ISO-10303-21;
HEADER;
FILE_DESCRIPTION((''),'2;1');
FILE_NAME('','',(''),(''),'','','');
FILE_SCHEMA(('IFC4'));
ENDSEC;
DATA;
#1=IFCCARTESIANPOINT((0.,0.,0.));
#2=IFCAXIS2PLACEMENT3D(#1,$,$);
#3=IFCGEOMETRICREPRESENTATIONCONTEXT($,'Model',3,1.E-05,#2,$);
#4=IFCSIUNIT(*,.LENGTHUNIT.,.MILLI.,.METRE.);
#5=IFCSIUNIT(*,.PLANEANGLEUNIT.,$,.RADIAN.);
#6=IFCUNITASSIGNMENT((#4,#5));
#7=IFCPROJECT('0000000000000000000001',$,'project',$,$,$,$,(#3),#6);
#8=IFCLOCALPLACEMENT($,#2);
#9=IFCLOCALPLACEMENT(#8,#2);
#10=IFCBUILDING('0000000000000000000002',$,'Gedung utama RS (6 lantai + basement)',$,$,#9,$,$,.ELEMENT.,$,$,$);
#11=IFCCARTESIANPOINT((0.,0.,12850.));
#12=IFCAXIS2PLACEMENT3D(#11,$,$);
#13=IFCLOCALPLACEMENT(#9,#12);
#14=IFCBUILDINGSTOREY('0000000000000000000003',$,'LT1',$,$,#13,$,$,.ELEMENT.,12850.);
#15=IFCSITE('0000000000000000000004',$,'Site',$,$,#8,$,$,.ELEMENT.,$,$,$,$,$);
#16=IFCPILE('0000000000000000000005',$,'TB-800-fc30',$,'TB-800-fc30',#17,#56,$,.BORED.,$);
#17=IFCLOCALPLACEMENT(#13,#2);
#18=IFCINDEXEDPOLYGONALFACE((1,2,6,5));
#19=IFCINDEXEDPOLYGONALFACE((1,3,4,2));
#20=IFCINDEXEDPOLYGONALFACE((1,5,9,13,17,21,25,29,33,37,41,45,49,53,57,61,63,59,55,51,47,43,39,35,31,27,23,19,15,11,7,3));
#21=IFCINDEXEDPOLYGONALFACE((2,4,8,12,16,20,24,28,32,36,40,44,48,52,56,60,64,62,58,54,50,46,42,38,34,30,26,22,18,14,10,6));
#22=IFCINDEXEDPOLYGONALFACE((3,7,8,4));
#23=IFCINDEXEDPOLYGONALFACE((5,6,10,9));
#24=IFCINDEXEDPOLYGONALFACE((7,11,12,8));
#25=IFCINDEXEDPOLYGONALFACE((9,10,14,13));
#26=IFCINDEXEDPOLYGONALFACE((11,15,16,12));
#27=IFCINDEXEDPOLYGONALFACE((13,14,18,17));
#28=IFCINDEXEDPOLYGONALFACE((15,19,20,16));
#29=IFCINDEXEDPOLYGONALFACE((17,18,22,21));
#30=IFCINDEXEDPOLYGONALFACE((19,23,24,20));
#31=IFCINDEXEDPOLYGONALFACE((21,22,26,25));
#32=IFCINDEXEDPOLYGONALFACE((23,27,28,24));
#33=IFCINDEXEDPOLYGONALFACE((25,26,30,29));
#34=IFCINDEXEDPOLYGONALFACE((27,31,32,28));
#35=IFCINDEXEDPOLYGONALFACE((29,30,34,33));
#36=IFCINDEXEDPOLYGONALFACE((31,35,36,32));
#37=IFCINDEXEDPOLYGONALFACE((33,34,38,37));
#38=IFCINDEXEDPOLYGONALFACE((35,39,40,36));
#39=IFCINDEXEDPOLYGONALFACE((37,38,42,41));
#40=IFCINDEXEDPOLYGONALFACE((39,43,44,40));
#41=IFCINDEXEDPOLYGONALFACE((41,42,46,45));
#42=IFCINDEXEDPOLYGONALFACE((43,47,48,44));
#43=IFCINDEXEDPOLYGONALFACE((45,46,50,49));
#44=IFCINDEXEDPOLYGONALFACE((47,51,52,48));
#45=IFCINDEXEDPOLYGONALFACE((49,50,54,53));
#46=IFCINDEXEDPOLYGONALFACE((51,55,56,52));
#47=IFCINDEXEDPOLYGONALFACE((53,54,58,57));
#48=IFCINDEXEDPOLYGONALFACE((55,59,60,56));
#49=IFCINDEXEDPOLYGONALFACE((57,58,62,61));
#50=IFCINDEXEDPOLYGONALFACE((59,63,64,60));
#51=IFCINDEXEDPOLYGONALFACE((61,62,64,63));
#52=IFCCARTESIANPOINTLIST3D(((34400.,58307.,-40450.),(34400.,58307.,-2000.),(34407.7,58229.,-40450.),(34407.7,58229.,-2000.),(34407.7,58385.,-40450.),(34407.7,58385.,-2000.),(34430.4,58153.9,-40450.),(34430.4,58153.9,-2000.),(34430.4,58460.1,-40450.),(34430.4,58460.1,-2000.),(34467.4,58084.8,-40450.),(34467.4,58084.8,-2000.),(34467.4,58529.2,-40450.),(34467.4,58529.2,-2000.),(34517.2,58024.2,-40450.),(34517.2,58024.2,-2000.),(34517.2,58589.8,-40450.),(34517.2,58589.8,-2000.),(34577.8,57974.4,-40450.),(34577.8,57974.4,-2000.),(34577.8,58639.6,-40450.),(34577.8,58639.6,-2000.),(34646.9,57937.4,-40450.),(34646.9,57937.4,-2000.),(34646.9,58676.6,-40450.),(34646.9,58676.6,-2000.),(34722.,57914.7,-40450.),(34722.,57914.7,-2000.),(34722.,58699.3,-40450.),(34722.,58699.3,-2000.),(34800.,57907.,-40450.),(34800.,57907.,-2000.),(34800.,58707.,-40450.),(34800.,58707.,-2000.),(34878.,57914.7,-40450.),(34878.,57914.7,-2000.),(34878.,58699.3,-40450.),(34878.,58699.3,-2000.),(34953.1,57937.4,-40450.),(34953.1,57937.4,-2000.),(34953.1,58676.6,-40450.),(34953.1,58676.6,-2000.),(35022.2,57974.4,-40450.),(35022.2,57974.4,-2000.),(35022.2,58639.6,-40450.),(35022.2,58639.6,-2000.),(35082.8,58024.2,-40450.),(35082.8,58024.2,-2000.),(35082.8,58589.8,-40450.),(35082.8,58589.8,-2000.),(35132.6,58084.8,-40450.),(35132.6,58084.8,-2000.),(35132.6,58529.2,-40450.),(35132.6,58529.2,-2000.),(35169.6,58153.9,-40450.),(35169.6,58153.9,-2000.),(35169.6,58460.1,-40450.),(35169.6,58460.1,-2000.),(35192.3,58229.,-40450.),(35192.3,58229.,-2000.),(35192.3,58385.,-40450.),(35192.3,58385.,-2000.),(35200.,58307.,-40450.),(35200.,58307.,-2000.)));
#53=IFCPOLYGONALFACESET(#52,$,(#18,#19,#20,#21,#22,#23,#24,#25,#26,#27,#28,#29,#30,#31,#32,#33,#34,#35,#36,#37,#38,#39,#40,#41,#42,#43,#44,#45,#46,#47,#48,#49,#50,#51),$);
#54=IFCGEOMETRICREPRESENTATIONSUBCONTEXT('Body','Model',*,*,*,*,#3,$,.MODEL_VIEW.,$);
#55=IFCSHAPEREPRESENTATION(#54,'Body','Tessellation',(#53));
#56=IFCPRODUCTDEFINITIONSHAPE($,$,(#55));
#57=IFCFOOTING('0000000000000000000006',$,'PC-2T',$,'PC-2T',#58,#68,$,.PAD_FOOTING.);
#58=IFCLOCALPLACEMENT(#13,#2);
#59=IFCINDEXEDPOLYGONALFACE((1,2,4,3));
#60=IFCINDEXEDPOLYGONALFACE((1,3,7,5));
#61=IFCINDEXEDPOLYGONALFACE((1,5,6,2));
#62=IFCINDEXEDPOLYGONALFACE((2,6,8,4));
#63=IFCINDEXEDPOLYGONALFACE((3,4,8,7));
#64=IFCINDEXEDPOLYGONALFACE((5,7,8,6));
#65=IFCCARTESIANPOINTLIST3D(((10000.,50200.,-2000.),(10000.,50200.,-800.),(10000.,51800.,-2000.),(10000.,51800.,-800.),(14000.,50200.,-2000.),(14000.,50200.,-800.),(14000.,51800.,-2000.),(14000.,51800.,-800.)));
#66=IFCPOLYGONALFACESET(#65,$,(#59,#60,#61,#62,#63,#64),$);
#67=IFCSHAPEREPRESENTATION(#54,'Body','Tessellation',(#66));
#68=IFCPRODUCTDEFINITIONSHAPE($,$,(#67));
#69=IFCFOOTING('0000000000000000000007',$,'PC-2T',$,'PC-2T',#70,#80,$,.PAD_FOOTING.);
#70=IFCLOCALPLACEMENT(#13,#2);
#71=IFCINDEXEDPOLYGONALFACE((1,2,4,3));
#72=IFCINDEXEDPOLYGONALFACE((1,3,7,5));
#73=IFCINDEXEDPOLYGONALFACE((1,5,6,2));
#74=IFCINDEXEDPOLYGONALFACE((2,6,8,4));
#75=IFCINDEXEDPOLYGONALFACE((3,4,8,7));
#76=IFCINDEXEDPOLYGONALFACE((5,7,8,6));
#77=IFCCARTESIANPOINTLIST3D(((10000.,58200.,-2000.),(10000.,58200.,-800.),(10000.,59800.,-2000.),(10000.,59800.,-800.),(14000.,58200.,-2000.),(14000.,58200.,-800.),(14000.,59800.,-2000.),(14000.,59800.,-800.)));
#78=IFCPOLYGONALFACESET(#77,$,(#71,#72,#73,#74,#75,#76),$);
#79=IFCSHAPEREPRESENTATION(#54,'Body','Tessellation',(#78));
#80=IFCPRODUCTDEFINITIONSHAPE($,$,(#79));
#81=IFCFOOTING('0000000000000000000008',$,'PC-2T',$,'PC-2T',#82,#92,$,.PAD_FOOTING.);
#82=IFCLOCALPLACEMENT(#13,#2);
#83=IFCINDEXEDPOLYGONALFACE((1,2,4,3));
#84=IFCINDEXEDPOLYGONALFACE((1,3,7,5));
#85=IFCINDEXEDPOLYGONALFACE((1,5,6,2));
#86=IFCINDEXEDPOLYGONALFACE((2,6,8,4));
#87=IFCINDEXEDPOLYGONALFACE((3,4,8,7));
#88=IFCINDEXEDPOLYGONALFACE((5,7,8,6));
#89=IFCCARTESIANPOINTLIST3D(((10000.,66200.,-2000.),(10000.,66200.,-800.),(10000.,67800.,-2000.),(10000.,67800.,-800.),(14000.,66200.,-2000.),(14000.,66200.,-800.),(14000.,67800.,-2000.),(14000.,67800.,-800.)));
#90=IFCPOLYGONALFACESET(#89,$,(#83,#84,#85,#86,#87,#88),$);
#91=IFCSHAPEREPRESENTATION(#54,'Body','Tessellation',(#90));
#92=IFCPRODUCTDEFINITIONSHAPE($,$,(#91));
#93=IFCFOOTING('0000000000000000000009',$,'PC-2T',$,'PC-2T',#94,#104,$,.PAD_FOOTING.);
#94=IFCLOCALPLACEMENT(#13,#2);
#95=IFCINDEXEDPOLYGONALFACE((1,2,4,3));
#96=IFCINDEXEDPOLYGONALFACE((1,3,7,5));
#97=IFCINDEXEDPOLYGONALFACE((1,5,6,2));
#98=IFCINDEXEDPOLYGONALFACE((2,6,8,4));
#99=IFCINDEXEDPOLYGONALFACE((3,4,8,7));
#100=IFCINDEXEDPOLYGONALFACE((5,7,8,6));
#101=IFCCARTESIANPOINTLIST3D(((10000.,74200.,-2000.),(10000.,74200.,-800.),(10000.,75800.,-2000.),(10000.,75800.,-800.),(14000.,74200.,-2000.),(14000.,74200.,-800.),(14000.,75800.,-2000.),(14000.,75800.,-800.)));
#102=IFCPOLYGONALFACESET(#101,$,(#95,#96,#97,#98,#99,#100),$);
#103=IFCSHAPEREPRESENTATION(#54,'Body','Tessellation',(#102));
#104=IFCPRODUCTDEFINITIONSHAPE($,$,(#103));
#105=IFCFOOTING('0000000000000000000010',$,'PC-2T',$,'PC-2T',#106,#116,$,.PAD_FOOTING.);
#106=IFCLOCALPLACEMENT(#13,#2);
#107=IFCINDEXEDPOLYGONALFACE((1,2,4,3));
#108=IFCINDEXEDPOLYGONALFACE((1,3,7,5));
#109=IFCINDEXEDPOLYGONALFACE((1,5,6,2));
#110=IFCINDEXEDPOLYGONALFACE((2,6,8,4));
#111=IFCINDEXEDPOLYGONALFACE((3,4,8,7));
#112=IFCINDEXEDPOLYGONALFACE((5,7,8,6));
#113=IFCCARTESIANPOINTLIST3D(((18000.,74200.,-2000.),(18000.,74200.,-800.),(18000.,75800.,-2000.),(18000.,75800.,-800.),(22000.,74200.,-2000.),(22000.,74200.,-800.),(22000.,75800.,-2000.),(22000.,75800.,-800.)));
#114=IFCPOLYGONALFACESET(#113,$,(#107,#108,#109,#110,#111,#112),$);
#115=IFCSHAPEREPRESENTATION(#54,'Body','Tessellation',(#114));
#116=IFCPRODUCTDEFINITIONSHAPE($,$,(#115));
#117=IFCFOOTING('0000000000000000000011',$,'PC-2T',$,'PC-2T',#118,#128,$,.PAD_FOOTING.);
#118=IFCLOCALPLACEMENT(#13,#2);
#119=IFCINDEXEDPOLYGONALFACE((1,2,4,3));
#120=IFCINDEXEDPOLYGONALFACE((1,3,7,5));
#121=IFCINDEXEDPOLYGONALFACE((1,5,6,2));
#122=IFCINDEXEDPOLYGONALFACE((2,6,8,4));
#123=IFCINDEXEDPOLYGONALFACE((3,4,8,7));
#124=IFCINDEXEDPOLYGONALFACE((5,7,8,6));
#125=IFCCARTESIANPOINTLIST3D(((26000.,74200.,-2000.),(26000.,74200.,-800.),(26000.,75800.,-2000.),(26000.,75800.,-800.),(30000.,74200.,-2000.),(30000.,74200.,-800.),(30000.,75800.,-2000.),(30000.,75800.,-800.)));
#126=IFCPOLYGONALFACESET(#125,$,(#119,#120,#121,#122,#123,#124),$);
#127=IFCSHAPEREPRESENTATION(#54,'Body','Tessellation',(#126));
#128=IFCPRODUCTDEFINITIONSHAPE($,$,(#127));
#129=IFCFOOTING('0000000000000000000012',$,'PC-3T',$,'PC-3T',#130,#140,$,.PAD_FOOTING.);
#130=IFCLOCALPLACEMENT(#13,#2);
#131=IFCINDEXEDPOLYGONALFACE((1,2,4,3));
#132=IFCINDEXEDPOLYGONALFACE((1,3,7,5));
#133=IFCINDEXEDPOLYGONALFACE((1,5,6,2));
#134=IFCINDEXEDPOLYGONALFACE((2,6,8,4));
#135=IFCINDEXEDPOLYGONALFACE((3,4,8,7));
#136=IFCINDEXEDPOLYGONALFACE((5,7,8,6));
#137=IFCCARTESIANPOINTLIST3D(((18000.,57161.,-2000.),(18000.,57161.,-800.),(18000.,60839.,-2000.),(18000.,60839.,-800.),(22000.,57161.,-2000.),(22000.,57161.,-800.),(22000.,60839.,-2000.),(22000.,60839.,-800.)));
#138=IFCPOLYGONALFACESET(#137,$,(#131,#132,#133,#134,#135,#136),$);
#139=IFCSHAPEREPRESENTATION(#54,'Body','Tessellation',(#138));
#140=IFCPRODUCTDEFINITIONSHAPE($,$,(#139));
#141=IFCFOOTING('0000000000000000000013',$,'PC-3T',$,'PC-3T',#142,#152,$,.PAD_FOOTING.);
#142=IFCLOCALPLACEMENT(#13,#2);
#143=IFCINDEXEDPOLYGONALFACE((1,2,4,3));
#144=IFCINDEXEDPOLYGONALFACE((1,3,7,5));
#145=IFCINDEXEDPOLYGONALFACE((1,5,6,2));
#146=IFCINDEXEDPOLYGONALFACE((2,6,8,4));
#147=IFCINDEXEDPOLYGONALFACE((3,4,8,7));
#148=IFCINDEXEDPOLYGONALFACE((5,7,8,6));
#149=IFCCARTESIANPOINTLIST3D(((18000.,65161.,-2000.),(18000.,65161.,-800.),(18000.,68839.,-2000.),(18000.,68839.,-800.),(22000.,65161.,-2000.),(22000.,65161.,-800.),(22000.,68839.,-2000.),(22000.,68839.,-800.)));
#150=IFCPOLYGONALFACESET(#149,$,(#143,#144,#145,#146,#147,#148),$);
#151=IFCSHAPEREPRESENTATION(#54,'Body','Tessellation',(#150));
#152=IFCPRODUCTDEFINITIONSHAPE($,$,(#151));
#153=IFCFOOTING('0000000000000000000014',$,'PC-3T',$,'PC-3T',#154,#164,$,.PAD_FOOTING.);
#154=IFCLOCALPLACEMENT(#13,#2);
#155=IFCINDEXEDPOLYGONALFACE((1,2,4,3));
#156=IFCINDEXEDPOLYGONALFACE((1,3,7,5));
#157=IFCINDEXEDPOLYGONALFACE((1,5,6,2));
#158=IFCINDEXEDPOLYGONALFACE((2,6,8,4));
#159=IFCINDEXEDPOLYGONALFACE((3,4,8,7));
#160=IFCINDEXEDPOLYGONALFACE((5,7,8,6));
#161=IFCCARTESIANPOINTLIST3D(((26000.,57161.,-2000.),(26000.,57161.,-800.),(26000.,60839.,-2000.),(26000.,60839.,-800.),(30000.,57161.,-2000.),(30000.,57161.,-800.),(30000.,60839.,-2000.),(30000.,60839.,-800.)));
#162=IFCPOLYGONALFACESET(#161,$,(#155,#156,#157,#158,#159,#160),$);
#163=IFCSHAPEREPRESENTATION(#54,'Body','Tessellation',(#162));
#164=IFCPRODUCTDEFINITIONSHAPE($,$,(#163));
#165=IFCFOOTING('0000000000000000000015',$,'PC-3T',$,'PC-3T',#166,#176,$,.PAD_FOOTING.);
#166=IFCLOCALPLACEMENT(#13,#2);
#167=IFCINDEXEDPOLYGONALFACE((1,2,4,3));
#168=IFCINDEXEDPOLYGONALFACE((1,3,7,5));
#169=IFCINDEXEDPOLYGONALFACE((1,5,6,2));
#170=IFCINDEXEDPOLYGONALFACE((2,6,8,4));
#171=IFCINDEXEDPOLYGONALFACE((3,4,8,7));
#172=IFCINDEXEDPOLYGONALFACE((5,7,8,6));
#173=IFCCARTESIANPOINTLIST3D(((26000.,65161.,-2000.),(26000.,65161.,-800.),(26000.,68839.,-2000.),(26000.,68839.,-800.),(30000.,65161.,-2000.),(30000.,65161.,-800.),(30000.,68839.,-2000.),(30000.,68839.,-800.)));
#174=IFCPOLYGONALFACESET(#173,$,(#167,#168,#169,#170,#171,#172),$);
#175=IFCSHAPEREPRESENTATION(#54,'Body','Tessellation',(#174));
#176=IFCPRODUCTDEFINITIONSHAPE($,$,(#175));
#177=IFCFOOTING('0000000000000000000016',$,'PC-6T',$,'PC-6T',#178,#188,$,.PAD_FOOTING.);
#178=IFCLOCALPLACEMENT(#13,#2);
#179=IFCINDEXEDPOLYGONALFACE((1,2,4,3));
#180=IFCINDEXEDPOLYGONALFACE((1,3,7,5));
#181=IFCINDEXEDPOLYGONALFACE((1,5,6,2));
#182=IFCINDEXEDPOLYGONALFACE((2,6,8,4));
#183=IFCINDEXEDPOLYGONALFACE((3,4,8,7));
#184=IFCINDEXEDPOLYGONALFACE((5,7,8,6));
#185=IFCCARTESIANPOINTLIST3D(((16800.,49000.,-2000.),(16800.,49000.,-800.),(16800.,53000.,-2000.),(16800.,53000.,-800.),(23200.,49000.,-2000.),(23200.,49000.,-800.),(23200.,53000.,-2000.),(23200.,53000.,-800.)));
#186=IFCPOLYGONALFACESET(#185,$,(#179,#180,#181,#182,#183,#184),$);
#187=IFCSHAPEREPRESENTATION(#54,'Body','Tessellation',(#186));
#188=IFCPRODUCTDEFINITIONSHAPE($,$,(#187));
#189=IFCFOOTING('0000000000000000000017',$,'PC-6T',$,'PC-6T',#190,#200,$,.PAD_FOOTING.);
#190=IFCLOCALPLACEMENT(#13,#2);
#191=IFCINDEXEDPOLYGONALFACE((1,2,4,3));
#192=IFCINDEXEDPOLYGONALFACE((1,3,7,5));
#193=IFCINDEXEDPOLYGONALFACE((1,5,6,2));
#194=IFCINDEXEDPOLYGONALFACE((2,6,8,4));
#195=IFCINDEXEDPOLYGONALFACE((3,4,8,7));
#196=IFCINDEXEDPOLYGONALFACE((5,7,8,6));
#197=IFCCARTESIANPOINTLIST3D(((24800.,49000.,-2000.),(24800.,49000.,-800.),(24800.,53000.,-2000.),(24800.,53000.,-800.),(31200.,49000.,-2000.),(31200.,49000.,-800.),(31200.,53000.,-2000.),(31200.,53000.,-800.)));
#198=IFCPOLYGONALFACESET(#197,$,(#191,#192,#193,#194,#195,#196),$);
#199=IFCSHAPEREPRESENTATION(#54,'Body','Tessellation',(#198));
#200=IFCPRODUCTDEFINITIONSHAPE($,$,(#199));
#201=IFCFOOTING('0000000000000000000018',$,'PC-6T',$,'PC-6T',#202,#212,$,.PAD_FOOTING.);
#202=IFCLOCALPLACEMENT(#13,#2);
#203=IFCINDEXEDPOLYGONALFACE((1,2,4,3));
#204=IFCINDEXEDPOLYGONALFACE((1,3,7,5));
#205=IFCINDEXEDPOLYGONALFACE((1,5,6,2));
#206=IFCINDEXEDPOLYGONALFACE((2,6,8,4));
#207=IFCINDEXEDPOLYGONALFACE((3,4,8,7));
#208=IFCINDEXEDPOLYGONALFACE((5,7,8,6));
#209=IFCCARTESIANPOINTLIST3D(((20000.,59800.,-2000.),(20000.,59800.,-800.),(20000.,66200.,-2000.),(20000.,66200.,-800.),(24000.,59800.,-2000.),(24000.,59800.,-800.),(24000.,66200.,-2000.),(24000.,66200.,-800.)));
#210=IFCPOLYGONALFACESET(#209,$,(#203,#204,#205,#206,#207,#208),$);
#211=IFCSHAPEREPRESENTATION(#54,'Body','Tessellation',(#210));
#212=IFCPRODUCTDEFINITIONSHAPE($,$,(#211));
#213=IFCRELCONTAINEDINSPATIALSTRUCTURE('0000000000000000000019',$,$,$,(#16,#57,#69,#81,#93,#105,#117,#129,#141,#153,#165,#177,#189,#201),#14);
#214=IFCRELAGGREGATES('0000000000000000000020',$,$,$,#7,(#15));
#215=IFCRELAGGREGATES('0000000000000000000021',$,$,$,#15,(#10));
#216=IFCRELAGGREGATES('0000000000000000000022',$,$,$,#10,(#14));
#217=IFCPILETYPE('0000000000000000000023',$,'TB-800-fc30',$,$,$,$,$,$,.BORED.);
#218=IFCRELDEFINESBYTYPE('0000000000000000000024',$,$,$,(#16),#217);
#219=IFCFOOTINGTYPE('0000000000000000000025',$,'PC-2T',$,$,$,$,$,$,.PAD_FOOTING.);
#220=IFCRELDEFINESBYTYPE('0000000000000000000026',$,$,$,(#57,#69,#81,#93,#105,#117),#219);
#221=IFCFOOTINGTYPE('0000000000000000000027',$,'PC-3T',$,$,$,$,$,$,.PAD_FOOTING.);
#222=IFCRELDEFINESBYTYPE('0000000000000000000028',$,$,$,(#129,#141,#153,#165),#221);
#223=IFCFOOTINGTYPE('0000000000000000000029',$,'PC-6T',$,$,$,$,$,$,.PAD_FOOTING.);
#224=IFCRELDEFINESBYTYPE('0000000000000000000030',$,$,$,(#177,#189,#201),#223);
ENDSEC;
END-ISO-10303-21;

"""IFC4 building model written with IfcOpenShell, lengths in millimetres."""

from ifc_helpers import new_model, si_unit, frame, origin, origin_2d, place, context, subcontext, project, spatial, rectangle, circle, extrude, material_profile, profile_set, profile_usage, type_object, element, save


model = new_model("IFC4")

# Units and contexts
model_context = context("Model", 3, precision=1e-05, world=origin())
body_context = subcontext(model_context, "Body", "Model", "MODEL_VIEW")
ifc_project = project(units=[si_unit("LENGTHUNIT", "METRE", prefix="MILLI"), si_unit("PLANEANGLEUNIT", "RADIAN")], contexts=[model_context])

# Site, building, storey
site_placement = place(None, origin())
site = spatial("IfcSite", under=ifc_project, at=site_placement, Name="Site", CompositionType="ELEMENT")
building_placement = place(site_placement, origin())
building = spatial("IfcBuilding", under=site, at=building_placement, Name="Gedung utama RS (6 lantai + basement)", CompositionType="ELEMENT")
storey_placement = place(building_placement, frame((0.0, 0.0, 12850.0)))
storey = spatial("IfcBuildingStorey", under=building, at=storey_placement, Name="LT1", CompositionType="ELEMENT", Elevation=12850.0)

# Pile
ifc_material_profile_1 = material_profile(None, circle(Radius=400.0, at=origin_2d()), Name="TB-800-fc30")
ifc_profile_set_1 = profile_set([ifc_material_profile_1], Name="TB-800-fc30")
ifc_profile_usage_1 = profile_usage(ifc_profile_set_1, cardinal=5)
pile_type = type_object("IfcPileType", Name="TB-800-fc30", PredefinedType="BORED", material=ifc_profile_set_1)
for number, where, z_axis, x_axis, name in (
    (1, (34800.0, 58307.0, -40450.0), (0.0, 0.0, 1.0), (1.0, 0.0, 0.0), "TB-800-fc30"),
):
    element("IfcPile", number, at=place(storey_placement, frame(where, z_axis=z_axis, x_axis=x_axis)), inside=storey, type_object=pile_type, material=ifc_profile_usage_1, Name=name, ObjectType="TB-800-fc30", PredefinedType="BORED", context=body_context, shape_type="SweptSolid", body=[
        extrude(circle(Radius=400.0, at=origin_2d()), origin(), (0.0, 0.0, 1.0), 38450.0),
    ])

# Footings
ifc_material_profile_2 = material_profile(None, rectangle(XDim=4000.0, YDim=1600.0, at=origin_2d()), Name="PC-2T")
ifc_profile_set_2 = profile_set([ifc_material_profile_2], Name="PC-2T")
ifc_profile_usage_2 = profile_usage(ifc_profile_set_2, cardinal=5)
footing_type_1 = type_object("IfcFootingType", Name="PC-2T", PredefinedType="PAD_FOOTING", material=ifc_profile_set_2)
for number, where, z_axis, x_axis, name in (
    (2, (12000.0, 51000.0, -2000.0), (0.0, 0.0, 1.0), (1.0, 0.0, 0.0), "PC-2T"),
    (3, (12000.0, 59000.0, -2000.0), (0.0, 0.0, 1.0), (1.0, 0.0, 0.0), "PC-2T"),
    (4, (12000.0, 67000.0, -2000.0), (0.0, 0.0, 1.0), (1.0, 0.0, 0.0), "PC-2T"),
    (5, (12000.0, 75000.0, -2000.0), (0.0, 0.0, 1.0), (1.0, 0.0, 0.0), "PC-2T"),
    (6, (20000.0, 75000.0, -2000.0), (0.0, 0.0, 1.0), (1.0, 0.0, 0.0), "PC-2T"),
    (7, (28000.0, 75000.0, -2000.0), (0.0, 0.0, 1.0), (1.0, 0.0, 0.0), "PC-2T"),
):
    element("IfcFooting", number, at=place(storey_placement, frame(where, z_axis=z_axis, x_axis=x_axis)), inside=storey, type_object=footing_type_1, material=ifc_profile_usage_2, Name=name, ObjectType="PC-2T", PredefinedType="PAD_FOOTING", context=body_context, shape_type="SweptSolid", body=[
        extrude(rectangle(XDim=4000.0, YDim=1600.0, at=origin_2d()), origin(), (0.0, 0.0, 1.0), 1200.0),
    ])
ifc_material_profile_3 = material_profile(None, rectangle(XDim=4000.0, YDim=3678.0, at=origin_2d()), Name="PC-3T")
ifc_profile_set_3 = profile_set([ifc_material_profile_3], Name="PC-3T")
ifc_profile_usage_3 = profile_usage(ifc_profile_set_3, cardinal=5)
footing_type_2 = type_object("IfcFootingType", Name="PC-3T", PredefinedType="PAD_FOOTING", material=ifc_profile_set_3)
for number, where, z_axis, x_axis, name in (
    (8, (20000.0, 59000.0, -2000.0), (0.0, 0.0, 1.0), (1.0, 0.0, 0.0), "PC-3T"),
    (9, (20000.0, 67000.0, -2000.0), (0.0, 0.0, 1.0), (1.0, 0.0, 0.0), "PC-3T"),
    (10, (28000.0, 59000.0, -2000.0), (0.0, 0.0, 1.0), (1.0, 0.0, 0.0), "PC-3T"),
    (11, (28000.0, 67000.0, -2000.0), (0.0, 0.0, 1.0), (1.0, 0.0, 0.0), "PC-3T"),
):
    element("IfcFooting", number, at=place(storey_placement, frame(where, z_axis=z_axis, x_axis=x_axis)), inside=storey, type_object=footing_type_2, material=ifc_profile_usage_3, Name=name, ObjectType="PC-3T", PredefinedType="PAD_FOOTING", context=body_context, shape_type="SweptSolid", body=[
        extrude(rectangle(XDim=4000.0, YDim=3678.0, at=origin_2d()), origin(), (0.0, 0.0, 1.0), 1200.0),
    ])
ifc_material_profile_4 = material_profile(None, rectangle(XDim=6400.0, YDim=4000.0, at=origin_2d()), Name="PC-6T")
ifc_profile_set_4 = profile_set([ifc_material_profile_4], Name="PC-6T")
ifc_profile_usage_4 = profile_usage(ifc_profile_set_4, cardinal=5)
footing_type_3 = type_object("IfcFootingType", Name="PC-6T", PredefinedType="PAD_FOOTING", material=ifc_profile_set_4)
for number, where, z_axis, x_axis, name in (
    (12, (20000.0, 51000.0, -2000.0), (0.0, 0.0, 1.0), (1.0, 0.0, 0.0), "PC-6T"),
    (13, (28000.0, 51000.0, -2000.0), (0.0, 0.0, 1.0), (1.0, 0.0, 0.0), "PC-6T"),
    (14, (22000.0, 63000.0, -2000.0), (0.0, 0.0, 1.0), (0.0, 1.0, 0.0), "PC-6T"),
):
    element("IfcFooting", number, at=place(storey_placement, frame(where, z_axis=z_axis, x_axis=x_axis)), inside=storey, type_object=footing_type_3, material=ifc_profile_usage_4, Name=name, ObjectType="PC-6T", PredefinedType="PAD_FOOTING", context=body_context, shape_type="SweptSolid", body=[
        extrude(rectangle(XDim=6400.0, YDim=4000.0, at=origin_2d()), origin(), (0.0, 0.0, 1.0), 1200.0),
    ])

save(model, "model.ifc")
